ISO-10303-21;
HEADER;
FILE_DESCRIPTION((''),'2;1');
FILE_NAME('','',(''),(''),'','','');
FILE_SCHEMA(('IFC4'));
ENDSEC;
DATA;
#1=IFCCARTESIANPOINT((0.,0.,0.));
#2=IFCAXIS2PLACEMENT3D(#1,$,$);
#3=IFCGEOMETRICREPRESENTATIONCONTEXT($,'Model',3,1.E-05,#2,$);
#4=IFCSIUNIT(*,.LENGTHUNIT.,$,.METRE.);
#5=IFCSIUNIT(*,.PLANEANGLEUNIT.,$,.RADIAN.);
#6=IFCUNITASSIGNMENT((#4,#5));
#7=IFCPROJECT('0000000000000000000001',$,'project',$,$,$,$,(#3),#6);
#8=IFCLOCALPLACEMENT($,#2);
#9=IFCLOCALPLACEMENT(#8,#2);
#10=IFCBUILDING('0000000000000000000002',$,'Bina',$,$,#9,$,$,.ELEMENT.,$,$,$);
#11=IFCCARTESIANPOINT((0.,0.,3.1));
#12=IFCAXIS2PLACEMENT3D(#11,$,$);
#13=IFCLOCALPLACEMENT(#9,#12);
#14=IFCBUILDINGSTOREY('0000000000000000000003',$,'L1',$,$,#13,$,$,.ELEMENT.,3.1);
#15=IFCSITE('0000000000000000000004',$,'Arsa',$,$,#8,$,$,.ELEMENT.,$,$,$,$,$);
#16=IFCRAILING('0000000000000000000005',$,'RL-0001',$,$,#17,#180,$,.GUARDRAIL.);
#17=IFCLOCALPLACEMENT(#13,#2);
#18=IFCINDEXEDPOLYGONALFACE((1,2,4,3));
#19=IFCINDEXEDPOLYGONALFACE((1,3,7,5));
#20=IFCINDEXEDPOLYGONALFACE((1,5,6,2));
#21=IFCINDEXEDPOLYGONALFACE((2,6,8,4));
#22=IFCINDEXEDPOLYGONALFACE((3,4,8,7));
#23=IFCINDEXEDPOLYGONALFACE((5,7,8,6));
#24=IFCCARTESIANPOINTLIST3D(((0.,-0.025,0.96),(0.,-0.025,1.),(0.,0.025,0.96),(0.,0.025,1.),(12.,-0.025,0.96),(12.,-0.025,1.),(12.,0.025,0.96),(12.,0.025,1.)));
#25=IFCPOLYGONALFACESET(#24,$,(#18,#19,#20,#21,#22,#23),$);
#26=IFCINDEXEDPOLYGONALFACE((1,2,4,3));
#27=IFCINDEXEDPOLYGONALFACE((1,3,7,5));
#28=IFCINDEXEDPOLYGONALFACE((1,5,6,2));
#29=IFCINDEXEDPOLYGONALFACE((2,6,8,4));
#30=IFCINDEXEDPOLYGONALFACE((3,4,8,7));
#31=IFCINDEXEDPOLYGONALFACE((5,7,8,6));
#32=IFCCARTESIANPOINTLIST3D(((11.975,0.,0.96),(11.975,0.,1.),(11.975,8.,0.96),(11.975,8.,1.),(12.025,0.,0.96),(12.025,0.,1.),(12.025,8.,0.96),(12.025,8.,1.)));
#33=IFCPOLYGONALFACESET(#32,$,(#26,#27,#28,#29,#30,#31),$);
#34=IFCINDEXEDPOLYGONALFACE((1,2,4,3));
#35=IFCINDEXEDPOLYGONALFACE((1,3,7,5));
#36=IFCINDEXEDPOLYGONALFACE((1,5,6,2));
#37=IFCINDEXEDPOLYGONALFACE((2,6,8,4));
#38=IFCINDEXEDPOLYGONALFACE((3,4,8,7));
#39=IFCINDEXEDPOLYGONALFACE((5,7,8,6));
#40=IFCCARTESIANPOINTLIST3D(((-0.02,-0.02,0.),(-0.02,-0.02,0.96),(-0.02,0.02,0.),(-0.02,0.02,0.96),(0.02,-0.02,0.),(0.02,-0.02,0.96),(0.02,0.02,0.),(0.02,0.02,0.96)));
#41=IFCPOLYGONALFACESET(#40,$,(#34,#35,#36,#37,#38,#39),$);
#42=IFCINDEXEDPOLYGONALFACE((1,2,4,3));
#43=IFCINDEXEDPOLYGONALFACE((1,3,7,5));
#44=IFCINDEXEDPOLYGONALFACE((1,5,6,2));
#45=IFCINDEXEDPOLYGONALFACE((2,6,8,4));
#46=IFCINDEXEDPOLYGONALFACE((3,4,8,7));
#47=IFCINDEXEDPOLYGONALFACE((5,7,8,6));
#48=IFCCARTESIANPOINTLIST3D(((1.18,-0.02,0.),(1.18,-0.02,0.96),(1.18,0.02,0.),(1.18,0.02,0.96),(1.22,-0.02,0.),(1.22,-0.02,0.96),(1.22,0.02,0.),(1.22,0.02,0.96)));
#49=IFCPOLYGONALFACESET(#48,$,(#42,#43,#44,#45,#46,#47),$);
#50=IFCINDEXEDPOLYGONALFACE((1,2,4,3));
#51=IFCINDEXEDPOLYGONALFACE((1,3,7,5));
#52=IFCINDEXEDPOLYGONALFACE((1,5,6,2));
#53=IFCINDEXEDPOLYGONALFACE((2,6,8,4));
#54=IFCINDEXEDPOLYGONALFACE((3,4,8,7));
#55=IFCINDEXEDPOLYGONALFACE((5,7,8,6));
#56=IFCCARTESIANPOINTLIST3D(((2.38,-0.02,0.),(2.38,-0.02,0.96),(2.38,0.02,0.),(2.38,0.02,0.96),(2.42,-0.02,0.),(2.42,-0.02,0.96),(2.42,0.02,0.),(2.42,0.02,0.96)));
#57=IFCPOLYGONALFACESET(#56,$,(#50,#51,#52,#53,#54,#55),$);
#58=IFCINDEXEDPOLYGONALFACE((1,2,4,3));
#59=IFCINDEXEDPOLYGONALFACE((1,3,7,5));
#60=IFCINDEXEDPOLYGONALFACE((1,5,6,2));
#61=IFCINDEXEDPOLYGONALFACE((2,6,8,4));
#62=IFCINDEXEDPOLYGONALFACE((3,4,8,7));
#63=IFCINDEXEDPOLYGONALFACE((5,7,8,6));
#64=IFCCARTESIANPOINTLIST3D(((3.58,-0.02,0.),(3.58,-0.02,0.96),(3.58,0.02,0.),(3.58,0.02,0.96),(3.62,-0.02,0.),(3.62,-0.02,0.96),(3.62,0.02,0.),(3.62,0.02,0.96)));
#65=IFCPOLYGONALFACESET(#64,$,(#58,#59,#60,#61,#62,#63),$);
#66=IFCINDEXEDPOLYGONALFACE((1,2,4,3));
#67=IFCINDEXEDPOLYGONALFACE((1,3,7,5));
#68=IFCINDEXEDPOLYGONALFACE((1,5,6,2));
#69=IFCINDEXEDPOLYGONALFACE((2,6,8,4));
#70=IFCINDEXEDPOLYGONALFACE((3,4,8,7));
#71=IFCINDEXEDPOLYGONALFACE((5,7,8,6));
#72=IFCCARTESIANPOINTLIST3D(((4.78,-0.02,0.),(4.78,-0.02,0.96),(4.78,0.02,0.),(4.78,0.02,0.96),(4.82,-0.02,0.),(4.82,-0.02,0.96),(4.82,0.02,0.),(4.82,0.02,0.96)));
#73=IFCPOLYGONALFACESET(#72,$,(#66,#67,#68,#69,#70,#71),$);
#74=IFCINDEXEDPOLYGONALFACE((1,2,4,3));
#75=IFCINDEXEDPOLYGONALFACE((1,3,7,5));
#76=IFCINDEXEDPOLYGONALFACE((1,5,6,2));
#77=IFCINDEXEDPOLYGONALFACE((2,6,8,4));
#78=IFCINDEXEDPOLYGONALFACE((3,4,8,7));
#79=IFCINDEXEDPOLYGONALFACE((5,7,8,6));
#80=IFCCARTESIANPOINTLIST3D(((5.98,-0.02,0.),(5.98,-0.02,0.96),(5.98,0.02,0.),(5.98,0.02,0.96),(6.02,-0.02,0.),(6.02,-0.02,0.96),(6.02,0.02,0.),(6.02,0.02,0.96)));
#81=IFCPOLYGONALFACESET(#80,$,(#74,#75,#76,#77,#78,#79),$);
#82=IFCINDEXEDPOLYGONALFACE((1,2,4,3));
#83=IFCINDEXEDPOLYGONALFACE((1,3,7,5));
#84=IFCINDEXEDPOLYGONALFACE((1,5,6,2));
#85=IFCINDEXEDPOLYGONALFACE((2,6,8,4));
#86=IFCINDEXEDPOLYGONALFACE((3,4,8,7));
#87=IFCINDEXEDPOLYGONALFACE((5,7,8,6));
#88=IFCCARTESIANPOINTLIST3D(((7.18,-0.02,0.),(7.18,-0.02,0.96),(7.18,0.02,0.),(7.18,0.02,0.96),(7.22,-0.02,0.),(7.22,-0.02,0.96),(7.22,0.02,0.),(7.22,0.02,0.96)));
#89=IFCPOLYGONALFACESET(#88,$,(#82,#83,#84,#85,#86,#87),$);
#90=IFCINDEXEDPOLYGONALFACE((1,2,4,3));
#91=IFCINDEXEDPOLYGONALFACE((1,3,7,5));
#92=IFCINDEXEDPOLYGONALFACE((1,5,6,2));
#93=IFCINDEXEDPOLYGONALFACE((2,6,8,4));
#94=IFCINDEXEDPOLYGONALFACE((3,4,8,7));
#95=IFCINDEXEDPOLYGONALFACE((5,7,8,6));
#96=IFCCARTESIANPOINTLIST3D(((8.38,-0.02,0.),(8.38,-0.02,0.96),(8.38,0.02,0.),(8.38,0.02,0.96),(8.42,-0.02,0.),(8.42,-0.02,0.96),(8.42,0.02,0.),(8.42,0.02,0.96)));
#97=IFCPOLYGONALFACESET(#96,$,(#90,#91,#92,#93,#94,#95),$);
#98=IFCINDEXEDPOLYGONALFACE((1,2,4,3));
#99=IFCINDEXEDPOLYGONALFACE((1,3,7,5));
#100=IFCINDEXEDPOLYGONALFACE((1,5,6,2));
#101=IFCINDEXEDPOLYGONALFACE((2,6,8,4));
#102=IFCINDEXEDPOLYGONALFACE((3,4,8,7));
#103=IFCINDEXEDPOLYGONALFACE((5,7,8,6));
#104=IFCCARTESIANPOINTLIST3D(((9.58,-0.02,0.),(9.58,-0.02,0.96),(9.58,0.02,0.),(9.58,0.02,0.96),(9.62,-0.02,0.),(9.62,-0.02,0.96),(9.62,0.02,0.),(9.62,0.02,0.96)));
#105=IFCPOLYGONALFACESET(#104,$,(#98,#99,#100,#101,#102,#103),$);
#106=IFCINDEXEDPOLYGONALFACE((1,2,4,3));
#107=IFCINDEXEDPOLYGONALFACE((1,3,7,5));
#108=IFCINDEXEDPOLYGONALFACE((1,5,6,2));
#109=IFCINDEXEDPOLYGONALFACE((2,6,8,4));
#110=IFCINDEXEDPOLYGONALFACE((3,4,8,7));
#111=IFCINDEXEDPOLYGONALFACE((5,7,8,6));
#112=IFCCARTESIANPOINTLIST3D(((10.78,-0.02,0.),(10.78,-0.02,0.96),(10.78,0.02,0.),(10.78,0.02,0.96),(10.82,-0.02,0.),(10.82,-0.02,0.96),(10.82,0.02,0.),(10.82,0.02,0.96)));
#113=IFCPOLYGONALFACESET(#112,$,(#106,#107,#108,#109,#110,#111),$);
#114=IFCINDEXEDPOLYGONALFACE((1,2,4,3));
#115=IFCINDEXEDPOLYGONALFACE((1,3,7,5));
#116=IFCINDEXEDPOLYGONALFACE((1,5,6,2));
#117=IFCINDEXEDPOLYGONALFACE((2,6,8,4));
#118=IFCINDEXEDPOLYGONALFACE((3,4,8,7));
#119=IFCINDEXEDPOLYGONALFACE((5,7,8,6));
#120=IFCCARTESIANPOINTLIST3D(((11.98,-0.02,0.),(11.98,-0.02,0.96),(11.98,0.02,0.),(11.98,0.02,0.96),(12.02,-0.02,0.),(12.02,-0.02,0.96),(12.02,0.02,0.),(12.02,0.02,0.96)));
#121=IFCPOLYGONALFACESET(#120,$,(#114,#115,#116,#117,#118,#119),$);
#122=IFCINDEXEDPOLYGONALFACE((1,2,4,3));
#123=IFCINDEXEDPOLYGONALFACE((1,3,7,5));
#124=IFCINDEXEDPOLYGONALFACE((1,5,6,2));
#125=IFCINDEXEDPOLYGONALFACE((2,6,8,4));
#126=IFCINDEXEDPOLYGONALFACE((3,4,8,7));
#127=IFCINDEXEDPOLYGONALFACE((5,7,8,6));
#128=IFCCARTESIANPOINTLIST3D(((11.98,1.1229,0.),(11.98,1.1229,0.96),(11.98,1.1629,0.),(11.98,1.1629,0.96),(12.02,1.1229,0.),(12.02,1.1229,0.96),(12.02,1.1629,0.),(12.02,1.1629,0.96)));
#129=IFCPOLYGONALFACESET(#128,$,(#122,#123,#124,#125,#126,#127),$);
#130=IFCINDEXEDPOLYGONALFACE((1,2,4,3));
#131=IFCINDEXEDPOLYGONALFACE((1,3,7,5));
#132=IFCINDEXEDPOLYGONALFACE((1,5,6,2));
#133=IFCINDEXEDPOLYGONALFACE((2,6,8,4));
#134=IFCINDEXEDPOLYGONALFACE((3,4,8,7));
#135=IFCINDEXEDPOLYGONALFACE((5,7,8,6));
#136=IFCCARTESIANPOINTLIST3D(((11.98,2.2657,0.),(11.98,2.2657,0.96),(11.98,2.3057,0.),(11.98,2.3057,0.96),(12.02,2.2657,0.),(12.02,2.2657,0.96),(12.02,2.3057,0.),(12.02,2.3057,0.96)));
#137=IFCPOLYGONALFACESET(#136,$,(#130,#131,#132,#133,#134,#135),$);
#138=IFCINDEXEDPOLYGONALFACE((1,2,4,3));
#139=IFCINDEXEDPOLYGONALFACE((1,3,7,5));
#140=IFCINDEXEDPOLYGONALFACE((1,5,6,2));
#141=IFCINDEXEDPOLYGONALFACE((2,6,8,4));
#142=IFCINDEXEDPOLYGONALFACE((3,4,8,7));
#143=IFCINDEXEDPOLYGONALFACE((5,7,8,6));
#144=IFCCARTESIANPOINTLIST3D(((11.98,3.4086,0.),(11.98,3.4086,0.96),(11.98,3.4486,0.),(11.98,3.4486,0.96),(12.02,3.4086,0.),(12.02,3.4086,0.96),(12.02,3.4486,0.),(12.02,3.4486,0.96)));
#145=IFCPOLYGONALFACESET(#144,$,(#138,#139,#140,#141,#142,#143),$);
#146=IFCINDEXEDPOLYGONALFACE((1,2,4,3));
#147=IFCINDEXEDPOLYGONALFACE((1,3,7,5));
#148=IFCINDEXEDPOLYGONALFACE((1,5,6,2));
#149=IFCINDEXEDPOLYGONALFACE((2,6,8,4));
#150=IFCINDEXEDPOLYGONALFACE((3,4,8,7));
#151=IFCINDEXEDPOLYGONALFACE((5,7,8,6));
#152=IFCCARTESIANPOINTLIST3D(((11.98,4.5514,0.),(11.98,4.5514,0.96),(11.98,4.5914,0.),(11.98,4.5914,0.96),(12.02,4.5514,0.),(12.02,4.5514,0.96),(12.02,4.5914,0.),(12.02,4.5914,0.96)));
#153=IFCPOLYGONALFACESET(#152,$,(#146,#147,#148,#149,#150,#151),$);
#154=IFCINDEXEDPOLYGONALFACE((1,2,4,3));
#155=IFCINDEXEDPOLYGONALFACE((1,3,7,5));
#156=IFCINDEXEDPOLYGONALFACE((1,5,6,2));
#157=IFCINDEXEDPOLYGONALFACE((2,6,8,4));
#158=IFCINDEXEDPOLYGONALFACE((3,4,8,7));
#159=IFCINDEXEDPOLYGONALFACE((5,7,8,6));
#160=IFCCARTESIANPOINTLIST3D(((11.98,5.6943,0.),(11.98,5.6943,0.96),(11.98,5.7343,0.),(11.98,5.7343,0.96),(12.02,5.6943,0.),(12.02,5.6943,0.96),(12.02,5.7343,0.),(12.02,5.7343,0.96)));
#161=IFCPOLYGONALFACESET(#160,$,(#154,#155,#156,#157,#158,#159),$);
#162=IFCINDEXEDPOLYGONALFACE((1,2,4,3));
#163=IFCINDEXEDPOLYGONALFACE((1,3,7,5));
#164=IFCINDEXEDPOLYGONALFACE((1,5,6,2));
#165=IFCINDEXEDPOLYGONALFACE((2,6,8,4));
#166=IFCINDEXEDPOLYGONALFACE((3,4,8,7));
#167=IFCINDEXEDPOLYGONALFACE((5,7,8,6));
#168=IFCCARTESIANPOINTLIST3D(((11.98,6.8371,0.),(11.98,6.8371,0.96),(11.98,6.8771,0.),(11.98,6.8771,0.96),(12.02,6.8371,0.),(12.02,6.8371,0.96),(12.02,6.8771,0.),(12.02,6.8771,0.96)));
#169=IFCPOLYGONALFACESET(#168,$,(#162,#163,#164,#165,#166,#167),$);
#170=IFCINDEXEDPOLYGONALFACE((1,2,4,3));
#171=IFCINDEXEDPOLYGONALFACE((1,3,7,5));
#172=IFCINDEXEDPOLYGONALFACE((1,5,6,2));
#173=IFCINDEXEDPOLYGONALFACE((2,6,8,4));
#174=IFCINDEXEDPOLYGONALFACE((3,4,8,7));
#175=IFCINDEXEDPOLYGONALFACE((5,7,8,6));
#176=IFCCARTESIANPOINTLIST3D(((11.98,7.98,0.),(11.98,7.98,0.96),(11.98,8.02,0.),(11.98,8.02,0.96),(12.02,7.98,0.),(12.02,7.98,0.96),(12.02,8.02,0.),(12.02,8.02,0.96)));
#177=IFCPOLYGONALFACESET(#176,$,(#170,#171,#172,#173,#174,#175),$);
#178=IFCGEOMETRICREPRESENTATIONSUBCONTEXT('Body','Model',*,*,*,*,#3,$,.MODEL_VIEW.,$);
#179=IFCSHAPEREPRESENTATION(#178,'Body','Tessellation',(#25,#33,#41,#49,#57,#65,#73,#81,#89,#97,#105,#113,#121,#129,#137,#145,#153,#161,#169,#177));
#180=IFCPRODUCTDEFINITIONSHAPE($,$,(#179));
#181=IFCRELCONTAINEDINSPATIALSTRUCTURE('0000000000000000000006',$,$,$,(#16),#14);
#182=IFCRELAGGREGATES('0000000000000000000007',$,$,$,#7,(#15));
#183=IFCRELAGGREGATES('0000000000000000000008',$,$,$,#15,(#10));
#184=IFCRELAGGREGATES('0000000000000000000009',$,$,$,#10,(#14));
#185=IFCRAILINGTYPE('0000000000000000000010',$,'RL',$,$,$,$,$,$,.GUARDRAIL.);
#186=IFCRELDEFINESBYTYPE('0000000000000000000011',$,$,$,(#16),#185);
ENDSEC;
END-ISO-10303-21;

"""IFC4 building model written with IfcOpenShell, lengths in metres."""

from ifc_helpers import new_model, si_unit, frame, origin, origin_2d, place, context, subcontext, project, spatial, rectangle, extrude, type_object, element, save


model = new_model("IFC4")

# Units and contexts
model_context = context("Model", 3, precision=1e-05, world=origin())
body_context = subcontext(model_context, "Body", "Model", "MODEL_VIEW")
ifc_project = project(units=[si_unit("LENGTHUNIT", "METRE"), si_unit("PLANEANGLEUNIT", "RADIAN")], contexts=[model_context])

# Site, building, storey
site_placement = place(None, origin())
site = spatial("IfcSite", under=ifc_project, at=site_placement, Name="Arsa", CompositionType="ELEMENT")
building_placement = place(site_placement, origin())
building = spatial("IfcBuilding", under=site, at=building_placement, Name="Bina", CompositionType="ELEMENT")
storey_placement = place(building_placement, frame((0.0, 0.0, 3.1)))
storey = spatial("IfcBuildingStorey", under=building, at=storey_placement, Name="L1", CompositionType="ELEMENT", Elevation=3.1)

# Railing
railing_type = type_object("IfcRailingType", Name="RL", PredefinedType="GUARDRAIL")
railing_placement = place(storey_placement, origin())
element("IfcRailing", 1, at=railing_placement, inside=storey, type_object=railing_type, Name="RL-0001", PredefinedType="GUARDRAIL", context=body_context, shape_type="SweptSolid", body=[
    extrude(rectangle(XDim=0.04, YDim=0.05, at=origin_2d()), frame((0.0, 0.0, 0.98), z_axis=(1.0, 0.0, 0.0), x_axis=(0.0, 0.0, 1.0)), (0.0, 0.0, 1.0), 12.0),
    extrude(rectangle(XDim=0.04, YDim=0.05, at=origin_2d()), frame((12.0, 0.0, 0.98), z_axis=(0.0, 1.0, 0.0), x_axis=(0.0, 0.0, 1.0)), (0.0, 0.0, 1.0), 8.0),
    extrude(rectangle(XDim=0.04, YDim=0.04, at=origin_2d()), origin(), (0.0, 0.0, 1.0), 0.96),
    extrude(rectangle(XDim=0.04, YDim=0.04, at=origin_2d()), frame((1.2, 0.0, 0.0)), (0.0, 0.0, 1.0), 0.96),
    extrude(rectangle(XDim=0.04, YDim=0.04, at=origin_2d()), frame((2.4, 0.0, 0.0)), (0.0, 0.0, 1.0), 0.96),
    extrude(rectangle(XDim=0.04, YDim=0.04, at=origin_2d()), frame((3.6, 0.0, 0.0)), (0.0, 0.0, 1.0), 0.96),
    extrude(rectangle(XDim=0.04, YDim=0.04, at=origin_2d()), frame((4.8, 0.0, 0.0)), (0.0, 0.0, 1.0), 0.96),
    extrude(rectangle(XDim=0.04, YDim=0.04, at=origin_2d()), frame((6.0, 0.0, 0.0)), (0.0, 0.0, 1.0), 0.96),
    extrude(rectangle(XDim=0.04, YDim=0.04, at=origin_2d()), frame((7.2, 0.0, 0.0)), (0.0, 0.0, 1.0), 0.96),
    extrude(rectangle(XDim=0.04, YDim=0.04, at=origin_2d()), frame((8.4, 0.0, 0.0)), (0.0, 0.0, 1.0), 0.96),
    extrude(rectangle(XDim=0.04, YDim=0.04, at=origin_2d()), frame((9.6, 0.0, 0.0)), (0.0, 0.0, 1.0), 0.96),
    extrude(rectangle(XDim=0.04, YDim=0.04, at=origin_2d()), frame((10.8, 0.0, 0.0)), (0.0, 0.0, 1.0), 0.96),
    extrude(rectangle(XDim=0.04, YDim=0.04, at=origin_2d()), frame((12.0, 0.0, 0.0)), (0.0, 0.0, 1.0), 0.96),
    extrude(rectangle(XDim=0.04, YDim=0.04, at=origin_2d()), frame((12.0, 1.1429, 0.0)), (0.0, 0.0, 1.0), 0.96),
    extrude(rectangle(XDim=0.04, YDim=0.04, at=origin_2d()), frame((12.0, 2.2857, 0.0)), (0.0, 0.0, 1.0), 0.96),
    extrude(rectangle(XDim=0.04, YDim=0.04, at=origin_2d()), frame((12.0, 3.4286, 0.0)), (0.0, 0.0, 1.0), 0.96),
    extrude(rectangle(XDim=0.04, YDim=0.04, at=origin_2d()), frame((12.0, 4.5714, 0.0)), (0.0, 0.0, 1.0), 0.96),
    extrude(rectangle(XDim=0.04, YDim=0.04, at=origin_2d()), frame((12.0, 5.7143, 0.0)), (0.0, 0.0, 1.0), 0.96),
    extrude(rectangle(XDim=0.04, YDim=0.04, at=origin_2d()), frame((12.0, 6.8571, 0.0)), (0.0, 0.0, 1.0), 0.96),
    extrude(rectangle(XDim=0.04, YDim=0.04, at=origin_2d()), frame((12.0, 8.0, 0.0)), (0.0, 0.0, 1.0), 0.96),
])

save(model, "model.ifc")
